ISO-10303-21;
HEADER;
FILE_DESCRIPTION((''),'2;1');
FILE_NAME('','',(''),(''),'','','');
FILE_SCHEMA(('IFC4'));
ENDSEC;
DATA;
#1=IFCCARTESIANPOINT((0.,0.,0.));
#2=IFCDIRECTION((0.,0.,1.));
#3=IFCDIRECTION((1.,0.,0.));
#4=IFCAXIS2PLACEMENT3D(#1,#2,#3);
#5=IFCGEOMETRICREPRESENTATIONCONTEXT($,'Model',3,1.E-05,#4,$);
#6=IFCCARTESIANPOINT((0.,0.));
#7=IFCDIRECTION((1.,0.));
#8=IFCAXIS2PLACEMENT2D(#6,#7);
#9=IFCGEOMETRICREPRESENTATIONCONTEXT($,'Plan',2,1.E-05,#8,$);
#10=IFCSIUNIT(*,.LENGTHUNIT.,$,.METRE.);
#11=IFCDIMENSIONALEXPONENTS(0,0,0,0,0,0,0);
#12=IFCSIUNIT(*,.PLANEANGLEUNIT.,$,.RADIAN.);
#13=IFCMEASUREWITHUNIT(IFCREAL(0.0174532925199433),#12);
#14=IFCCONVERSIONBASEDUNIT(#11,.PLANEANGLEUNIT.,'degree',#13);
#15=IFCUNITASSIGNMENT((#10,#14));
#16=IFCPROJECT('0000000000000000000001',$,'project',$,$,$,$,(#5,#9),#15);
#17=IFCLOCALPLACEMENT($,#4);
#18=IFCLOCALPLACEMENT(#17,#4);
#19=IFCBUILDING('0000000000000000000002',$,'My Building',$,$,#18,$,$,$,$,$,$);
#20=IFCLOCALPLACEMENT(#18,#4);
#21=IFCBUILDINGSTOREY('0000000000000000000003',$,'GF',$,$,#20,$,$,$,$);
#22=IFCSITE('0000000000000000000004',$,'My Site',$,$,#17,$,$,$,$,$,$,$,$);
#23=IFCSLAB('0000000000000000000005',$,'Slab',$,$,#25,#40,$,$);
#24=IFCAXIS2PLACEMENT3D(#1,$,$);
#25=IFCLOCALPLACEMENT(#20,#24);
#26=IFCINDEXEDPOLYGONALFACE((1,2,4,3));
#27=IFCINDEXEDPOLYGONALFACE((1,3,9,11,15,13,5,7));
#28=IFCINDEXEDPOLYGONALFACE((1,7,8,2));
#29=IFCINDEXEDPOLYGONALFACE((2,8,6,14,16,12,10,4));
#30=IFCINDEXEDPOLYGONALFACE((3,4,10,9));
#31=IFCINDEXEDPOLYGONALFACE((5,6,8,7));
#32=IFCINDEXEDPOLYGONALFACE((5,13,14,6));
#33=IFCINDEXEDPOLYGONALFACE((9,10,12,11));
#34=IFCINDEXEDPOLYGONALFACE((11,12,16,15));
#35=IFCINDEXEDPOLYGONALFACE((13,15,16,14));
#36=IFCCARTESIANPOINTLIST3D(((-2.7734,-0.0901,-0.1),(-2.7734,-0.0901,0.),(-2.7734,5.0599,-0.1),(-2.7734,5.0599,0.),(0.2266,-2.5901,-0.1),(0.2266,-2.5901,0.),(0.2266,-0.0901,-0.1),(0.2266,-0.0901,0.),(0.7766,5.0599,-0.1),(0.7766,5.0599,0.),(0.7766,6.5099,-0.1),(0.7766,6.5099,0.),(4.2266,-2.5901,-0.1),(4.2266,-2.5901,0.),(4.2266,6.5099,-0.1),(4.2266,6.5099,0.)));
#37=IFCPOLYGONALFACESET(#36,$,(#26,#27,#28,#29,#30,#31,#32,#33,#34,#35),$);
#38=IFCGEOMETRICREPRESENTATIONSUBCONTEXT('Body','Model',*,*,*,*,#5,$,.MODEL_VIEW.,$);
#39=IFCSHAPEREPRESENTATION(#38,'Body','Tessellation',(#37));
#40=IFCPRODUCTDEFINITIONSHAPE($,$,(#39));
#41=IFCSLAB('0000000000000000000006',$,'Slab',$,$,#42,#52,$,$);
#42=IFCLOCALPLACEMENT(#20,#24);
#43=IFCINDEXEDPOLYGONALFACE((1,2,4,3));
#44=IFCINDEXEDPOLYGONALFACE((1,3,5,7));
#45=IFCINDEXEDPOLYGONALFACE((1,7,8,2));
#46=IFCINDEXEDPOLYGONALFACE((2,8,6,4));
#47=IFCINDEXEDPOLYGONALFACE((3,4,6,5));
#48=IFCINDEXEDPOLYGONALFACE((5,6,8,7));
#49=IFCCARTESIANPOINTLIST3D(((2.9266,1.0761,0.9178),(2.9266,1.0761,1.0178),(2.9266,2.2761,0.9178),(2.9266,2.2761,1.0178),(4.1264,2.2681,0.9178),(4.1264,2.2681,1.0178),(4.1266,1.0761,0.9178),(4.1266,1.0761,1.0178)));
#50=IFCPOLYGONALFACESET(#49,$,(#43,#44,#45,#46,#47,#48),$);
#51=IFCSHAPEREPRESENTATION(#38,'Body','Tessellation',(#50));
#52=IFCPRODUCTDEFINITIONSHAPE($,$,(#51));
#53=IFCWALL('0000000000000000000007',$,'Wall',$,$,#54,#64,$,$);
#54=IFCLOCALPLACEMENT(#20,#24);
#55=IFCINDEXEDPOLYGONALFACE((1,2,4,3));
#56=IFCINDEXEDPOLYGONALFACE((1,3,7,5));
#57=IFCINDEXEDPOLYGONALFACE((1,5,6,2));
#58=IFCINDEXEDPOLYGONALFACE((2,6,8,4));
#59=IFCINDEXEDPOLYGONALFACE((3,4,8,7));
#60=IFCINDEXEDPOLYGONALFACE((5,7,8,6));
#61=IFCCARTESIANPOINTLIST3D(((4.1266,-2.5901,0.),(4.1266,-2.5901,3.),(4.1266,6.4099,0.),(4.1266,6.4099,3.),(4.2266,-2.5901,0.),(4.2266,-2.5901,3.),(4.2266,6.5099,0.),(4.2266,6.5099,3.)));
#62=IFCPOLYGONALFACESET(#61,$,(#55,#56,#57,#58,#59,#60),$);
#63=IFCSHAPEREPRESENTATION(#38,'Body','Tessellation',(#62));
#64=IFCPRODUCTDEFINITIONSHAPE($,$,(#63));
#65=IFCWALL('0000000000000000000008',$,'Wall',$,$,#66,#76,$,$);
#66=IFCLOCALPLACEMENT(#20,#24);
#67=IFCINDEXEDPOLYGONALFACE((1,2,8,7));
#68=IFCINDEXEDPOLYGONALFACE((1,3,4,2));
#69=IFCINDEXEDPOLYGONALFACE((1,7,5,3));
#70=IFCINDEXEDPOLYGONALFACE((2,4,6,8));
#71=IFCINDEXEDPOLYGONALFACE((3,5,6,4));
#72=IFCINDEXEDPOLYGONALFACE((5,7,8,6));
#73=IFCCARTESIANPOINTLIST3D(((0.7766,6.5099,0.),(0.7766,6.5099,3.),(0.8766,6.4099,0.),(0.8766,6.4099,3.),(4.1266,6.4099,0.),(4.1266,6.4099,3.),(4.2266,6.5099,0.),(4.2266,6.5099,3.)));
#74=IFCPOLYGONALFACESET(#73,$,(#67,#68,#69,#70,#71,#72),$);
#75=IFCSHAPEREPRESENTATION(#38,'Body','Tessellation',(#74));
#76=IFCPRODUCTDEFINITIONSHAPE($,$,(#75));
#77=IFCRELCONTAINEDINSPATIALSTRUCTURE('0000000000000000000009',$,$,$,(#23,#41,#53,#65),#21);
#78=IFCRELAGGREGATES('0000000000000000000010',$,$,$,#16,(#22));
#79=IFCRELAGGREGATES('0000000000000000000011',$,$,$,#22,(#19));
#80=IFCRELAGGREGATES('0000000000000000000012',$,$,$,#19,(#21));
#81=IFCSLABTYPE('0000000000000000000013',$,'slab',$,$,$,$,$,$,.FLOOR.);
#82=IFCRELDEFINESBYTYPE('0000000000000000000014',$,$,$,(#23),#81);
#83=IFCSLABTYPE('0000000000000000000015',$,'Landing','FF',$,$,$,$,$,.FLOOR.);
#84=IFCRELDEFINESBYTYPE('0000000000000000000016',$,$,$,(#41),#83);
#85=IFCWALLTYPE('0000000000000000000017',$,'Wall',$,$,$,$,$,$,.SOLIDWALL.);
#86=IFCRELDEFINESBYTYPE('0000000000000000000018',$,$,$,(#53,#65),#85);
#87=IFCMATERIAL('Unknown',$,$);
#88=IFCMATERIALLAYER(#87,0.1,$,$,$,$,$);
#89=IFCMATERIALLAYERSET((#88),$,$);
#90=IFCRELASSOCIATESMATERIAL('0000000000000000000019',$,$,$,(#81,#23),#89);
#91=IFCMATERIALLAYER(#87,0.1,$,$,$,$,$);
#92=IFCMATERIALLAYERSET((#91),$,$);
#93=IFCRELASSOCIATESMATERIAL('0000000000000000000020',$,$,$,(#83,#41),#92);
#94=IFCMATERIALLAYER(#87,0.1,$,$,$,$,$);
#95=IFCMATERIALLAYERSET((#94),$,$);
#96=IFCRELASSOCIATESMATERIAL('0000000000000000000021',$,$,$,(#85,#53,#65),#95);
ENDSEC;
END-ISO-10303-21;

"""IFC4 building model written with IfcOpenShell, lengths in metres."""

from ifc_helpers import new_model, entity, si_unit, converted_unit, frame, origin_with_axes, origin_2d_with_axis, place, context, subcontext, project, spatial, line, indexed_curve, outline, extrude, material, layer, layer_set, layer_usage, type_object, element, save


model = new_model("IFC4")

# Units and contexts
model_context = context("Model", 3, precision=1e-05, world=origin_with_axes())
plan_context = context("Plan", 2, precision=1e-05, world=origin_2d_with_axis())
body_context_1 = subcontext(model_context, "Body", "Model", "MODEL_VIEW")
ifc_project = project(units=[si_unit("LENGTHUNIT", "METRE"), converted_unit("PLANEANGLEUNIT", "degree", entity("IfcReal", 0.0174532925199433), si_unit("PLANEANGLEUNIT", "RADIAN"), dimensions=[0, 0, 0, 0, 0, 0, 0])], contexts=[model_context, plan_context])

# Site, building, storey
site_placement = place(None, origin_with_axes())
site = spatial("IfcSite", under=ifc_project, at=site_placement, Name="My Site")
building_placement = place(site_placement, origin_with_axes())
building = spatial("IfcBuilding", under=site, at=building_placement, Name="My Building")
storey_placement = place(building_placement, origin_with_axes())
storey = spatial("IfcBuildingStorey", under=building, at=storey_placement, Name="GF")

# Slabs
ifc_material_1 = material(Name="Unknown")
ifc_layer_1 = layer(ifc_material_1, 0.1)
ifc_layer_set_1 = layer_set([ifc_layer_1])
ifc_layer_usage_1 = layer_usage(ifc_layer_set_1, "AXIS3", "POSITIVE", -0.1)
slab_type_1 = type_object("IfcSlabType", Name="slab", PredefinedType="FLOOR", material=ifc_layer_set_1)
slab_1_placement = place(storey_placement, frame((4.2266, -2.5901, 0.0), z_axis=(0.0, 0.0, 1.0), x_axis=(1.0, 0.0, 0.0)))
element("IfcSlab", 1, at=slab_1_placement, inside=storey, type_object=slab_type_1, material=ifc_layer_usage_1, Name="Slab", context=body_context_1, shape_type="SweptSolid", body=[
    extrude(outline(indexed_curve([(0.0, 0.0), (0.0, 9.1), (-3.45, 9.1), (-3.45, 7.65), (-7.0, 7.65), (-7.0, 2.5), (-4.0, 2.5), (-4.0, 0.0), (0.0, 0.0)])), frame((0.0, 0.0, -0.1), z_axis=(0.0, 0.0, 1.0), x_axis=(1.0, 0.0, 0.0)), (0.0, 0.0, 1.0), 0.1),
])
ifc_layer_2 = layer(ifc_material_1, 0.1)
ifc_layer_set_2 = layer_set([ifc_layer_2])
ifc_layer_usage_2 = layer_usage(ifc_layer_set_2, "AXIS3", "POSITIVE", -0.1)
slab_type_2 = type_object("IfcSlabType", Name="Landing", Description="FF", PredefinedType="FLOOR", material=ifc_layer_set_2)
slab_2_placement = place(storey_placement, frame((2.9266, 2.2761, 1.0178), z_axis=(0.0, 0.0, 1.0), x_axis=(1.0, 0.0, 0.0)))
element("IfcSlab", 2, at=slab_2_placement, inside=storey, type_object=slab_type_2, material=ifc_layer_usage_2, Name="Slab", context=body_context_1, shape_type="SweptSolid", body=[
    extrude(outline(indexed_curve([(0.0, 0.0), (0.0, -1.2), (1.2, -1.2), (1.1997, -0.0079), (0.0, 0.0)])), frame((0.0, 0.0, -0.1), z_axis=(0.0, 0.0, 1.0), x_axis=(1.0, 0.0, 0.0)), (0.0, 0.0, 1.0), 0.1),
])

# Shared definitions
ifc_layer_3 = layer(ifc_material_1, 0.1)
ifc_layer_set_3 = layer_set([ifc_layer_3])
wall_type = type_object("IfcWallType", Name="Wall", PredefinedType="SOLIDWALL", material=ifc_layer_set_3)

# Walls
ifc_layer_usage_3 = layer_usage(ifc_layer_set_3, "AXIS2", "POSITIVE", 0.0)
wall_1_placement = place(storey_placement, frame((4.2266, -2.5901, 0.0), z_axis=(0.0, 0.0, 1.0), x_axis=(0.0, 1.0, 0.0)))
element("IfcWall", 3, at=wall_1_placement, inside=storey, type_object=wall_type, material=ifc_layer_usage_3, Name="Wall", context=body_context_1, shape_type="SweptSolid", body=[
    extrude(outline(indexed_curve([(0.0, 0.0), (0.0, 0.1), (9.0, 0.1), (9.1, 0.0)], segments=[line(1, 2, 3, 4, 1)])), origin_with_axes(), (0.0, 0.0, 1.0), 3.0),
])
ifc_layer_usage_4 = layer_usage(ifc_layer_set_3, "AXIS2", "POSITIVE", 0.0)
wall_2_placement = place(storey_placement, frame((4.2266, 6.5099, 0.0), z_axis=(0.0, 0.0, 1.0), x_axis=(-1.0, 0.0, 0.0)))
element("IfcWall", 4, at=wall_2_placement, inside=storey, type_object=wall_type, material=ifc_layer_usage_4, Name="Wall", context=body_context_1, shape_type="SweptSolid", body=[
    extrude(outline(indexed_curve([(0.0, 0.0), (0.1, 0.1), (3.35, 0.1), (3.45, 0.0)], segments=[line(1, 2, 3, 4, 1)])), origin_with_axes(), (0.0, 0.0, 1.0), 3.0),
])

save(model, "model.ifc")
